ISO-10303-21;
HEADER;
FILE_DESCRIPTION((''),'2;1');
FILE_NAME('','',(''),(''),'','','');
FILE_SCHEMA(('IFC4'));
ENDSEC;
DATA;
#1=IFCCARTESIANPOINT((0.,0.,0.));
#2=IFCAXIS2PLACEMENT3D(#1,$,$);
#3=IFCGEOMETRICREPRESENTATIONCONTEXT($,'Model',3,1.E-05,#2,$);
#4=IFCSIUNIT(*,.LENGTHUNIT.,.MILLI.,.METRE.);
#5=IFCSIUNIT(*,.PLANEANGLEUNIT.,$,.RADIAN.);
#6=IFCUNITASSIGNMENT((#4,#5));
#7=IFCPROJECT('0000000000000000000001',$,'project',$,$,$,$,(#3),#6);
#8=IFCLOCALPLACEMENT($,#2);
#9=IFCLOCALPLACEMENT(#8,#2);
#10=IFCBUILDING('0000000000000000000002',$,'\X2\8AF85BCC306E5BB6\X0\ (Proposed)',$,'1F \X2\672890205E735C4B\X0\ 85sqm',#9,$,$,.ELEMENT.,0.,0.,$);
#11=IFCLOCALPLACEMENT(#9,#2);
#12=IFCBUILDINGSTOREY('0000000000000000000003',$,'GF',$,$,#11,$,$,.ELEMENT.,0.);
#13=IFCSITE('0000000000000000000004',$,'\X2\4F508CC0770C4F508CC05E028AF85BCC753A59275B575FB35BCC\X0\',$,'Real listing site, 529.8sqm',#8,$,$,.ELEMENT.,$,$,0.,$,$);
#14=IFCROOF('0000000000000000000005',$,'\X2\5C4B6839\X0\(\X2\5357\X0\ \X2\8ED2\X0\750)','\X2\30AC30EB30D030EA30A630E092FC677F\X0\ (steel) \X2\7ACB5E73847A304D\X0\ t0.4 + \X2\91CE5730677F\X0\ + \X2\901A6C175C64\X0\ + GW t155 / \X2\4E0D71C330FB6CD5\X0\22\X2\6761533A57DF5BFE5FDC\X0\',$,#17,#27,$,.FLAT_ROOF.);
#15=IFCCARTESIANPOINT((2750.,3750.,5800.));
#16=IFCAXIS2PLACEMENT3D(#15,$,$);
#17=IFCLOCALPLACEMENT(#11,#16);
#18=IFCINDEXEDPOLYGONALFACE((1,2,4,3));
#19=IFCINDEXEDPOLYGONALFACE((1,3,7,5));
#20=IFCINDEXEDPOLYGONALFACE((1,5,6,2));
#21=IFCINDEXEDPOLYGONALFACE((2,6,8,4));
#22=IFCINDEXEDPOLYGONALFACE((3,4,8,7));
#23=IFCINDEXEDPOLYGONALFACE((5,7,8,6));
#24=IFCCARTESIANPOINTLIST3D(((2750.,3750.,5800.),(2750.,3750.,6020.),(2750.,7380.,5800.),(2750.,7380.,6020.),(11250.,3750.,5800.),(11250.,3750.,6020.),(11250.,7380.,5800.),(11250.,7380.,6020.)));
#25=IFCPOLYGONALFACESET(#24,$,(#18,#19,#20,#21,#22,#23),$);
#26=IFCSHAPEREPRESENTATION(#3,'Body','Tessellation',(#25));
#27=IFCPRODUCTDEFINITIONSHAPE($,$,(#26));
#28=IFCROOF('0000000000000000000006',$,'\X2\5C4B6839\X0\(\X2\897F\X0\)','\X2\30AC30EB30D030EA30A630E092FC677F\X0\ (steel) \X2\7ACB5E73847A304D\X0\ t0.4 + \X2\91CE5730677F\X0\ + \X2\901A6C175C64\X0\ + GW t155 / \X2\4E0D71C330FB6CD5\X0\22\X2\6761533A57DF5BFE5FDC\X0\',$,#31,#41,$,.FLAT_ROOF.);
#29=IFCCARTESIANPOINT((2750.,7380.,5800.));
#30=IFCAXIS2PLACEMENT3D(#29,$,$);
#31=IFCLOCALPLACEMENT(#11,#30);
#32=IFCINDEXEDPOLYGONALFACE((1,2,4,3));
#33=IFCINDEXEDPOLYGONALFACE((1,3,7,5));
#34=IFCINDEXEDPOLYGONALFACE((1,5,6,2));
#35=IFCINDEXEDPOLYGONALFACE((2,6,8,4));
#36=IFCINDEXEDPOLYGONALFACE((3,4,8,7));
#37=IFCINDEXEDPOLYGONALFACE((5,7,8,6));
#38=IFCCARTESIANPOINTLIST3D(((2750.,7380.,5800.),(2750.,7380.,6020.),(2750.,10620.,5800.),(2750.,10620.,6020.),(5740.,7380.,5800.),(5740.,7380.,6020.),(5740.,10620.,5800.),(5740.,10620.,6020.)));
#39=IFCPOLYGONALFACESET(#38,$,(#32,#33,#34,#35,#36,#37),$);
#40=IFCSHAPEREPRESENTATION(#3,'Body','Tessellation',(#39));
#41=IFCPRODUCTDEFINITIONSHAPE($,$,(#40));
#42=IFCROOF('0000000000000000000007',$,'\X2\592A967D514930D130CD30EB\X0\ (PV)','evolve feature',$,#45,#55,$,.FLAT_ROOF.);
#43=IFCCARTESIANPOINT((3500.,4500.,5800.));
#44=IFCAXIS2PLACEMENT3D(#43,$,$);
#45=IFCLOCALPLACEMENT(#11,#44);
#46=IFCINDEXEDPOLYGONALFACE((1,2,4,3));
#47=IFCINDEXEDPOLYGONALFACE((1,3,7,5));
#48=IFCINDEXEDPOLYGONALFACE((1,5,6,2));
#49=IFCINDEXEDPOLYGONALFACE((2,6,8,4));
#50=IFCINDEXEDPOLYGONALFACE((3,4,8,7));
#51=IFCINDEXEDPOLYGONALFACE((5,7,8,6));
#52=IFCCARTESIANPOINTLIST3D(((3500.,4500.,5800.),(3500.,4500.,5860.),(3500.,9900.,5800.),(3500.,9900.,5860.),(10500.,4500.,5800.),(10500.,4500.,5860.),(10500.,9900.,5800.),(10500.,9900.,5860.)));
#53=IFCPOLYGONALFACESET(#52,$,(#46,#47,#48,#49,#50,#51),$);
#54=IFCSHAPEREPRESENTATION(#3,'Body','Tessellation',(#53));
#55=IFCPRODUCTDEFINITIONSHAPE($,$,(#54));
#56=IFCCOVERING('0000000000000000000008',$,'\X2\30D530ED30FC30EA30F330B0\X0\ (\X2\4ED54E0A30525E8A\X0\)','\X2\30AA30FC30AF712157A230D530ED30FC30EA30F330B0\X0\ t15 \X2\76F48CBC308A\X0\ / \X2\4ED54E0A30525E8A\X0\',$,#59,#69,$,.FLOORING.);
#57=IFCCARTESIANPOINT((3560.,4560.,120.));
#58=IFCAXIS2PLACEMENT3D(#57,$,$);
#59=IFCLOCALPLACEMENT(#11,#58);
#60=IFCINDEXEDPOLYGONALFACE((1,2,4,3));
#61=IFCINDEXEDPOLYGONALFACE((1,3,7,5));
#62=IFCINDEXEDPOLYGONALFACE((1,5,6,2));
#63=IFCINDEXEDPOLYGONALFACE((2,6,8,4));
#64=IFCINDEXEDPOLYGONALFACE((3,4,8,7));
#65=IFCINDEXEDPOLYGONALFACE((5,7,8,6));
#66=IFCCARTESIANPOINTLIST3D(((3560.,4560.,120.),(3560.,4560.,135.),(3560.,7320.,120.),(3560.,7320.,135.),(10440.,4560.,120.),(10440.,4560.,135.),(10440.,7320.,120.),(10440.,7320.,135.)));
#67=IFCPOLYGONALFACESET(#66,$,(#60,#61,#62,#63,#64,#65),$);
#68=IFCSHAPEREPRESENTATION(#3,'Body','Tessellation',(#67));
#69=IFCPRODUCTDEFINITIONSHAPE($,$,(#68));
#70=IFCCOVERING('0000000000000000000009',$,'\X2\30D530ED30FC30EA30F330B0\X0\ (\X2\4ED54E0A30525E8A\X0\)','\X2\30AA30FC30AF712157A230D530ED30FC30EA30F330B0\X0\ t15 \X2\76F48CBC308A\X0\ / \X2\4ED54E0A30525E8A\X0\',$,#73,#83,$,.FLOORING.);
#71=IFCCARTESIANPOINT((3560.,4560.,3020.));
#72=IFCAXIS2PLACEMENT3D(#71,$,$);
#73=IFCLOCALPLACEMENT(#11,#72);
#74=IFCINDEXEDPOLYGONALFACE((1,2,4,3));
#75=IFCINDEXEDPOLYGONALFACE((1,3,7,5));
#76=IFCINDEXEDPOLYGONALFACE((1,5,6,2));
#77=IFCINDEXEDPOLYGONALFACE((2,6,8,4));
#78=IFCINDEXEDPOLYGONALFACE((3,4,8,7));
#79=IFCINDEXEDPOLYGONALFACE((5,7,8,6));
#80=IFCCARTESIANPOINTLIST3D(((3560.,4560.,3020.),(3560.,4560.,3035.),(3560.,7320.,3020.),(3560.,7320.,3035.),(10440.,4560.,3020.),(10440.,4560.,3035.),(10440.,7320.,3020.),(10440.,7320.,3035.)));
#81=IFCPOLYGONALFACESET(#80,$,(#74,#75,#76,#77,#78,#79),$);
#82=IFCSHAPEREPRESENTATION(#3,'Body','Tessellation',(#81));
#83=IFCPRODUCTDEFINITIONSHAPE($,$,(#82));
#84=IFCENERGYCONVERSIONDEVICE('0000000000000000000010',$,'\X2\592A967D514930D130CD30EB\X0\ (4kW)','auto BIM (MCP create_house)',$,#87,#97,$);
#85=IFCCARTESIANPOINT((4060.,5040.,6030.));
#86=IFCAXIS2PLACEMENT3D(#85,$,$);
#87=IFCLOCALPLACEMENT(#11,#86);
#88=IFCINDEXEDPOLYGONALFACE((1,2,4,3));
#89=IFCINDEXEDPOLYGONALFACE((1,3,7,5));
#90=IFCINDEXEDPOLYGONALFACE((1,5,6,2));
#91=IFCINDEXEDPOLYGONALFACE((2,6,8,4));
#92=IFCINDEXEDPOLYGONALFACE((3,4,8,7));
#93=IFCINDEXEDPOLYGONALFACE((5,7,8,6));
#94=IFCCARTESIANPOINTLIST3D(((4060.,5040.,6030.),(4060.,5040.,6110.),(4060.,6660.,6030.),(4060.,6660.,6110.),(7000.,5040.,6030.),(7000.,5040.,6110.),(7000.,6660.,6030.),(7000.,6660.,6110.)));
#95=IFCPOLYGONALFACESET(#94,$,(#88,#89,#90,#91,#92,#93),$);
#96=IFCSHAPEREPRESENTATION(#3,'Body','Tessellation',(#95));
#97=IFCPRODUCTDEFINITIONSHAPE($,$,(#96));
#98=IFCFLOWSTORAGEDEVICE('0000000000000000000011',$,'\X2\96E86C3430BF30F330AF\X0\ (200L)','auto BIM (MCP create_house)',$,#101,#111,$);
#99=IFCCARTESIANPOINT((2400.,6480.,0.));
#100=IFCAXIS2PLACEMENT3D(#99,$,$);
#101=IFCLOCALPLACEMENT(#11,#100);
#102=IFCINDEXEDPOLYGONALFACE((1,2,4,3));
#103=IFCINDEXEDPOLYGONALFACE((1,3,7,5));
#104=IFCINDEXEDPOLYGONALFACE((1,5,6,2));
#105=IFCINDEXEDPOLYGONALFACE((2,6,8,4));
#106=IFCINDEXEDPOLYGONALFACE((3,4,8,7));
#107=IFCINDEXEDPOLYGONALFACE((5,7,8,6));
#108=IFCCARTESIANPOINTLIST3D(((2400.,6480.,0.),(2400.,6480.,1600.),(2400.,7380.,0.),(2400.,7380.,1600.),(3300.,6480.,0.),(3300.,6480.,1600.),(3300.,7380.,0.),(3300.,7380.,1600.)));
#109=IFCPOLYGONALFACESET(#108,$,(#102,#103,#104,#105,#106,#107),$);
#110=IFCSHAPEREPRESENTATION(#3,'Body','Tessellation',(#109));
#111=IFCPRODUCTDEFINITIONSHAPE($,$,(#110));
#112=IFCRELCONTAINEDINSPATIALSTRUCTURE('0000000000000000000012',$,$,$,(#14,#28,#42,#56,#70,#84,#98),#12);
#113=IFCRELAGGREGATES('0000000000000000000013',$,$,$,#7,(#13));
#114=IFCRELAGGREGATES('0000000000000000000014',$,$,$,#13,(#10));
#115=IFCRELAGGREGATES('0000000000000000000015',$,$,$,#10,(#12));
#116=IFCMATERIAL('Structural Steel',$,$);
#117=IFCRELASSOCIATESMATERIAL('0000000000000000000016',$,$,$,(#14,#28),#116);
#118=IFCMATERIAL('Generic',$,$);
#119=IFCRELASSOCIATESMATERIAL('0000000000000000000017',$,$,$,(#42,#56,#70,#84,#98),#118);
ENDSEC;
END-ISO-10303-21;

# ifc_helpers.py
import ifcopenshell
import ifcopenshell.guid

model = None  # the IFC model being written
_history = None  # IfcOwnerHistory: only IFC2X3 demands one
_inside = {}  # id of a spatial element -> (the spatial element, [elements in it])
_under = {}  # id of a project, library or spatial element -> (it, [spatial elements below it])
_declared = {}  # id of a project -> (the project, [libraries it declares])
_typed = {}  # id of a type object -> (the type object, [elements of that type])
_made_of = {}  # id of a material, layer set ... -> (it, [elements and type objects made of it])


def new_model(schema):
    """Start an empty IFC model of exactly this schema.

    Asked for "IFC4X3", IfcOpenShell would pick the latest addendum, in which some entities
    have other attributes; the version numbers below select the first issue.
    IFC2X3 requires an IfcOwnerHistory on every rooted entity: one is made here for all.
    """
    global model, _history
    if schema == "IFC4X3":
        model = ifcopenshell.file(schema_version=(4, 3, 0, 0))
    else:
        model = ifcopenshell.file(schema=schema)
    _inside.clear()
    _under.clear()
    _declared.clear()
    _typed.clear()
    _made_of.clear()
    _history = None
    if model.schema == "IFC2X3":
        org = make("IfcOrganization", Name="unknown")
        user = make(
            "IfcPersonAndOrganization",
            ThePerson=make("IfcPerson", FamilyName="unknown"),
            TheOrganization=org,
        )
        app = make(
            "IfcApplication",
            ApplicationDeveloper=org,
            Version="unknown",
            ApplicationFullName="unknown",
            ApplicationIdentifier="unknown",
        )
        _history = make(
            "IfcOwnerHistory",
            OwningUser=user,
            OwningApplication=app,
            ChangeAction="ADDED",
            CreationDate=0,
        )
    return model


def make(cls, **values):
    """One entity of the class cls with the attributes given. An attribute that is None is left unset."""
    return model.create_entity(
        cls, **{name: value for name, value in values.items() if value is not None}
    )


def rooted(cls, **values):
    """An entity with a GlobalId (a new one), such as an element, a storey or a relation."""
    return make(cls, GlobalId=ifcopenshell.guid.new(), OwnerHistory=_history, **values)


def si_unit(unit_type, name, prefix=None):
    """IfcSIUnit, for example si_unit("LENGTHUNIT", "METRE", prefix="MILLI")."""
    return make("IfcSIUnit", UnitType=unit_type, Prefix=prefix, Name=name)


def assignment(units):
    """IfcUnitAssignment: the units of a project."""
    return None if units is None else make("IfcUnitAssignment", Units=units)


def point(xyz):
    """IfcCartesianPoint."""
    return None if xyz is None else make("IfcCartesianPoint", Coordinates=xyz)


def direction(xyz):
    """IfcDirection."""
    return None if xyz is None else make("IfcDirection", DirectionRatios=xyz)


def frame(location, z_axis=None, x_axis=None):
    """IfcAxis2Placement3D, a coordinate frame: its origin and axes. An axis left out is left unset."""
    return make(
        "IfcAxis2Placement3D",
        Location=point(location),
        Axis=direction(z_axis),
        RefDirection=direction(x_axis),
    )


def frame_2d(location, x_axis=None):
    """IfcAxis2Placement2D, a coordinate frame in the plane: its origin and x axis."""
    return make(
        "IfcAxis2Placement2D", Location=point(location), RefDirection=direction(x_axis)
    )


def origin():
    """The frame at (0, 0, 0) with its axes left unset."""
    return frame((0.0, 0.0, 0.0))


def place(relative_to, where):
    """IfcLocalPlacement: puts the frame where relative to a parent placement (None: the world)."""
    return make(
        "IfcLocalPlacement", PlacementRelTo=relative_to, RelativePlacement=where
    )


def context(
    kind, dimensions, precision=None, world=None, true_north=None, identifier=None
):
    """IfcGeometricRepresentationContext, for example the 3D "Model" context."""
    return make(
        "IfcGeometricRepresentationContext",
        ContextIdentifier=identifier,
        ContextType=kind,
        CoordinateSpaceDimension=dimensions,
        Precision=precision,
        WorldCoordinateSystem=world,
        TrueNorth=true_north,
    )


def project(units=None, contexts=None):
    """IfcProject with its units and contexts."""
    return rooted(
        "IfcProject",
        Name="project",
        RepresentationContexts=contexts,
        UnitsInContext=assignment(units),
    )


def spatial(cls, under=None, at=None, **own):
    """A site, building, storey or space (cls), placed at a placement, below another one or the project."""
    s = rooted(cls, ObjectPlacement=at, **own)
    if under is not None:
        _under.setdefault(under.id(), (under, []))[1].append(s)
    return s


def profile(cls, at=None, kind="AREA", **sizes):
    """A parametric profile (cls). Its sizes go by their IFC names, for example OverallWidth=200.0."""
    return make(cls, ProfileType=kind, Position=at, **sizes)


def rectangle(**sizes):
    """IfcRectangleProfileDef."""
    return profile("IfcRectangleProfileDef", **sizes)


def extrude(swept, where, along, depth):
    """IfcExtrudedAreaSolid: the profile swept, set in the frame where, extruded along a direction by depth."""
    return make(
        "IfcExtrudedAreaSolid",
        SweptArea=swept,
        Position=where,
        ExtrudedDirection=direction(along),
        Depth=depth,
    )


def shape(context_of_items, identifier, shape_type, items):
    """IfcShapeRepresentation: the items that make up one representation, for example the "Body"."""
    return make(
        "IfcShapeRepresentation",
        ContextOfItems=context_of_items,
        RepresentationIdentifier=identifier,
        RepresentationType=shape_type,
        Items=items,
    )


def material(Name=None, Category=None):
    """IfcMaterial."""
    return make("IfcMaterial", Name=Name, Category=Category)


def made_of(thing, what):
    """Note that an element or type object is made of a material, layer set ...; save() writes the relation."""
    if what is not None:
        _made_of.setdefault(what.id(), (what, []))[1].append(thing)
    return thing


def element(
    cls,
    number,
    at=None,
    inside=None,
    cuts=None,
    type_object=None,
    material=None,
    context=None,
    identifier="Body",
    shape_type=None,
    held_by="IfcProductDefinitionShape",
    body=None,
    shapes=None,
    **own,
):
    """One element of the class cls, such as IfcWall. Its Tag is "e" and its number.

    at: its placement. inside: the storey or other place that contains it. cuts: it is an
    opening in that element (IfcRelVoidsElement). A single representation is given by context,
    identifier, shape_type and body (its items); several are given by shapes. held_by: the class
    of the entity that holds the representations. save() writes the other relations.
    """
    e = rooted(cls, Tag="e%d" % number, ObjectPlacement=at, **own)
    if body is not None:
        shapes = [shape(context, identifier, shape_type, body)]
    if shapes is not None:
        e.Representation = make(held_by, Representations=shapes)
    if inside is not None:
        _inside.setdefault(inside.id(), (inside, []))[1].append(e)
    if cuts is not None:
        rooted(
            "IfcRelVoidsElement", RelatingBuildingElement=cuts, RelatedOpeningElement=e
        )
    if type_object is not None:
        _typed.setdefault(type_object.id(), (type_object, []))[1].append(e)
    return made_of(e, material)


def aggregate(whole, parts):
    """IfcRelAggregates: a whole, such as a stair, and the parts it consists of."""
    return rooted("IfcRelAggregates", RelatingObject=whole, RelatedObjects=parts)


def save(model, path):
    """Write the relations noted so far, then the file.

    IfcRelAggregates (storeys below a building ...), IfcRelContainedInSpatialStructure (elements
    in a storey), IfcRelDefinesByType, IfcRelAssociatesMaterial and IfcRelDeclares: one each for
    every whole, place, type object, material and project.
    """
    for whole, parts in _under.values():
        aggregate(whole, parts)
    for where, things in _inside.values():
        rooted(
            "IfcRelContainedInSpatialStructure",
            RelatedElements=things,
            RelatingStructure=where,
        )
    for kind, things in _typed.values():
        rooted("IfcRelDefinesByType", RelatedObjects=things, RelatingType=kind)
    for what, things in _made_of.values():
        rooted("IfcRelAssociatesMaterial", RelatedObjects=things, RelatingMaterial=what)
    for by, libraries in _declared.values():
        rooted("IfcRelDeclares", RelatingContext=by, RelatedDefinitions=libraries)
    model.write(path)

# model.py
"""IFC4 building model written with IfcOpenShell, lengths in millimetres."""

from ifc_helpers import new_model, si_unit, frame, frame_2d, origin, place, context, project, spatial, rectangle, extrude, material, element, save


model = new_model("IFC4")

# Units and contexts
model_context = context("Model", 3, precision=1e-05, world=origin())
ifc_project = project(units=[si_unit("LENGTHUNIT", "METRE", prefix="MILLI"), si_unit("PLANEANGLEUNIT", "RADIAN")], contexts=[model_context])

# Site, building, storey
site_placement = place(None, origin())
site = spatial("IfcSite", under=ifc_project, at=site_placement, Name="佐賀県佐賀市諸富町大字徳富", ObjectType="Real listing site, 529.8sqm", CompositionType="ELEMENT", RefElevation=0.0)
building_placement = place(site_placement, origin())
building = spatial("IfcBuilding", under=site, at=building_placement, Name="諸富の家 (Proposed)", ObjectType="1F 木造平屋 85sqm", CompositionType="ELEMENT", ElevationOfRefHeight=0.0, ElevationOfTerrain=0.0)
storey_placement = place(building_placement, origin())
storey = spatial("IfcBuildingStorey", under=building, at=storey_placement, Name="GF", CompositionType="ELEMENT", Elevation=0.0)

# Shared definitions
ifc_material_1 = material(Name="Generic")

# Roofs
ifc_material_2 = material(Name="Structural Steel")
roof_1_placement = place(storey_placement, frame((2750.0, 3750.0, 5800.0)))
element("IfcRoof", 1, at=roof_1_placement, inside=storey, material=ifc_material_2, Name="屋根(南 軒750)", Description="ガルバリウム鋼板 (steel) 立平葺き t0.4 + 野地板 + 通気層 + GW t155 / 不燃・法22条区域対応", PredefinedType="FLAT_ROOF", context=model_context, shape_type="SweptSolid", body=[
    extrude(rectangle(XDim=8500.0, YDim=3630.0, at=frame_2d((4250.0, 1815.0))), frame((2750.0, 3750.0, 5800.0)), (0.0, 0.0, 1.0), 220.0),
])
roof_2_placement = place(storey_placement, frame((2750.0, 7380.0, 5800.0)))
element("IfcRoof", 2, at=roof_2_placement, inside=storey, material=ifc_material_2, Name="屋根(西)", Description="ガルバリウム鋼板 (steel) 立平葺き t0.4 + 野地板 + 通気層 + GW t155 / 不燃・法22条区域対応", PredefinedType="FLAT_ROOF", context=model_context, shape_type="SweptSolid", body=[
    extrude(rectangle(XDim=2990.0, YDim=3240.0, at=frame_2d((1495.0, 1620.0))), frame((2750.0, 7380.0, 5800.0)), (0.0, 0.0, 1.0), 220.0),
])
roof_3_placement = place(storey_placement, frame((3500.0, 4500.0, 5800.0)))
element("IfcRoof", 3, at=roof_3_placement, inside=storey, material=ifc_material_1, Name="太陽光パネル (PV)", Description="evolve feature", PredefinedType="FLAT_ROOF", context=model_context, shape_type="SweptSolid", body=[
    extrude(rectangle(XDim=7000.0, YDim=5400.0, at=frame_2d((3500.0, 2700.0))), frame((3500.0, 4500.0, 5800.0)), (0.0, 0.0, 1.0), 60.0),
])

# Coverings
covering_1_placement = place(storey_placement, frame((3560.0, 4560.0, 120.0)))
element("IfcCovering", 4, at=covering_1_placement, inside=storey, material=ifc_material_1, Name="フローリング (仕上げ床)", Description="オーク無垢フローリング t15 直貼り / 仕上げ床", PredefinedType="FLOORING", context=model_context, shape_type="SweptSolid", body=[
    extrude(rectangle(XDim=6880.0, YDim=2760.0, at=frame_2d((3440.0, 1380.0))), frame((3560.0, 4560.0, 120.0)), (0.0, 0.0, 1.0), 15.0),
])
covering_2_placement = place(storey_placement, frame((3560.0, 4560.0, 3020.0)))
element("IfcCovering", 5, at=covering_2_placement, inside=storey, material=ifc_material_1, Name="フローリング (仕上げ床)", Description="オーク無垢フローリング t15 直貼り / 仕上げ床", PredefinedType="FLOORING", context=model_context, shape_type="SweptSolid", body=[
    extrude(rectangle(XDim=6880.0, YDim=2760.0, at=frame_2d((3440.0, 1380.0))), frame((3560.0, 4560.0, 3020.0)), (0.0, 0.0, 1.0), 15.0),
])

# Energy conversion device
energy_conversion_device_placement = place(storey_placement, frame((4060.0, 5040.0, 6030.0)))
element("IfcEnergyConversionDevice", 6, at=energy_conversion_device_placement, inside=storey, material=ifc_material_1, Name="太陽光パネル (4kW)", Description="auto BIM (MCP create_house)", context=model_context, shape_type="SweptSolid", body=[
    extrude(rectangle(XDim=2940.0, YDim=1620.0, at=frame_2d((1470.0, 810.0))), frame((4060.0, 5040.0, 6030.0)), (0.0, 0.0, 1.0), 80.0),
])

# Flow storage device
flow_storage_device_placement = place(storey_placement, frame((2400.0, 6480.0, 0.0)))
element("IfcFlowStorageDevice", 7, at=flow_storage_device_placement, inside=storey, material=ifc_material_1, Name="雨水タンク (200L)", Description="auto BIM (MCP create_house)", context=model_context, shape_type="SweptSolid", body=[
    extrude(rectangle(XDim=900.0, YDim=900.0, at=frame_2d((450.0, 450.0))), frame((2400.0, 6480.0, 0.0)), (0.0, 0.0, 1.0), 1600.0),
])

save(model, "model.ifc")
